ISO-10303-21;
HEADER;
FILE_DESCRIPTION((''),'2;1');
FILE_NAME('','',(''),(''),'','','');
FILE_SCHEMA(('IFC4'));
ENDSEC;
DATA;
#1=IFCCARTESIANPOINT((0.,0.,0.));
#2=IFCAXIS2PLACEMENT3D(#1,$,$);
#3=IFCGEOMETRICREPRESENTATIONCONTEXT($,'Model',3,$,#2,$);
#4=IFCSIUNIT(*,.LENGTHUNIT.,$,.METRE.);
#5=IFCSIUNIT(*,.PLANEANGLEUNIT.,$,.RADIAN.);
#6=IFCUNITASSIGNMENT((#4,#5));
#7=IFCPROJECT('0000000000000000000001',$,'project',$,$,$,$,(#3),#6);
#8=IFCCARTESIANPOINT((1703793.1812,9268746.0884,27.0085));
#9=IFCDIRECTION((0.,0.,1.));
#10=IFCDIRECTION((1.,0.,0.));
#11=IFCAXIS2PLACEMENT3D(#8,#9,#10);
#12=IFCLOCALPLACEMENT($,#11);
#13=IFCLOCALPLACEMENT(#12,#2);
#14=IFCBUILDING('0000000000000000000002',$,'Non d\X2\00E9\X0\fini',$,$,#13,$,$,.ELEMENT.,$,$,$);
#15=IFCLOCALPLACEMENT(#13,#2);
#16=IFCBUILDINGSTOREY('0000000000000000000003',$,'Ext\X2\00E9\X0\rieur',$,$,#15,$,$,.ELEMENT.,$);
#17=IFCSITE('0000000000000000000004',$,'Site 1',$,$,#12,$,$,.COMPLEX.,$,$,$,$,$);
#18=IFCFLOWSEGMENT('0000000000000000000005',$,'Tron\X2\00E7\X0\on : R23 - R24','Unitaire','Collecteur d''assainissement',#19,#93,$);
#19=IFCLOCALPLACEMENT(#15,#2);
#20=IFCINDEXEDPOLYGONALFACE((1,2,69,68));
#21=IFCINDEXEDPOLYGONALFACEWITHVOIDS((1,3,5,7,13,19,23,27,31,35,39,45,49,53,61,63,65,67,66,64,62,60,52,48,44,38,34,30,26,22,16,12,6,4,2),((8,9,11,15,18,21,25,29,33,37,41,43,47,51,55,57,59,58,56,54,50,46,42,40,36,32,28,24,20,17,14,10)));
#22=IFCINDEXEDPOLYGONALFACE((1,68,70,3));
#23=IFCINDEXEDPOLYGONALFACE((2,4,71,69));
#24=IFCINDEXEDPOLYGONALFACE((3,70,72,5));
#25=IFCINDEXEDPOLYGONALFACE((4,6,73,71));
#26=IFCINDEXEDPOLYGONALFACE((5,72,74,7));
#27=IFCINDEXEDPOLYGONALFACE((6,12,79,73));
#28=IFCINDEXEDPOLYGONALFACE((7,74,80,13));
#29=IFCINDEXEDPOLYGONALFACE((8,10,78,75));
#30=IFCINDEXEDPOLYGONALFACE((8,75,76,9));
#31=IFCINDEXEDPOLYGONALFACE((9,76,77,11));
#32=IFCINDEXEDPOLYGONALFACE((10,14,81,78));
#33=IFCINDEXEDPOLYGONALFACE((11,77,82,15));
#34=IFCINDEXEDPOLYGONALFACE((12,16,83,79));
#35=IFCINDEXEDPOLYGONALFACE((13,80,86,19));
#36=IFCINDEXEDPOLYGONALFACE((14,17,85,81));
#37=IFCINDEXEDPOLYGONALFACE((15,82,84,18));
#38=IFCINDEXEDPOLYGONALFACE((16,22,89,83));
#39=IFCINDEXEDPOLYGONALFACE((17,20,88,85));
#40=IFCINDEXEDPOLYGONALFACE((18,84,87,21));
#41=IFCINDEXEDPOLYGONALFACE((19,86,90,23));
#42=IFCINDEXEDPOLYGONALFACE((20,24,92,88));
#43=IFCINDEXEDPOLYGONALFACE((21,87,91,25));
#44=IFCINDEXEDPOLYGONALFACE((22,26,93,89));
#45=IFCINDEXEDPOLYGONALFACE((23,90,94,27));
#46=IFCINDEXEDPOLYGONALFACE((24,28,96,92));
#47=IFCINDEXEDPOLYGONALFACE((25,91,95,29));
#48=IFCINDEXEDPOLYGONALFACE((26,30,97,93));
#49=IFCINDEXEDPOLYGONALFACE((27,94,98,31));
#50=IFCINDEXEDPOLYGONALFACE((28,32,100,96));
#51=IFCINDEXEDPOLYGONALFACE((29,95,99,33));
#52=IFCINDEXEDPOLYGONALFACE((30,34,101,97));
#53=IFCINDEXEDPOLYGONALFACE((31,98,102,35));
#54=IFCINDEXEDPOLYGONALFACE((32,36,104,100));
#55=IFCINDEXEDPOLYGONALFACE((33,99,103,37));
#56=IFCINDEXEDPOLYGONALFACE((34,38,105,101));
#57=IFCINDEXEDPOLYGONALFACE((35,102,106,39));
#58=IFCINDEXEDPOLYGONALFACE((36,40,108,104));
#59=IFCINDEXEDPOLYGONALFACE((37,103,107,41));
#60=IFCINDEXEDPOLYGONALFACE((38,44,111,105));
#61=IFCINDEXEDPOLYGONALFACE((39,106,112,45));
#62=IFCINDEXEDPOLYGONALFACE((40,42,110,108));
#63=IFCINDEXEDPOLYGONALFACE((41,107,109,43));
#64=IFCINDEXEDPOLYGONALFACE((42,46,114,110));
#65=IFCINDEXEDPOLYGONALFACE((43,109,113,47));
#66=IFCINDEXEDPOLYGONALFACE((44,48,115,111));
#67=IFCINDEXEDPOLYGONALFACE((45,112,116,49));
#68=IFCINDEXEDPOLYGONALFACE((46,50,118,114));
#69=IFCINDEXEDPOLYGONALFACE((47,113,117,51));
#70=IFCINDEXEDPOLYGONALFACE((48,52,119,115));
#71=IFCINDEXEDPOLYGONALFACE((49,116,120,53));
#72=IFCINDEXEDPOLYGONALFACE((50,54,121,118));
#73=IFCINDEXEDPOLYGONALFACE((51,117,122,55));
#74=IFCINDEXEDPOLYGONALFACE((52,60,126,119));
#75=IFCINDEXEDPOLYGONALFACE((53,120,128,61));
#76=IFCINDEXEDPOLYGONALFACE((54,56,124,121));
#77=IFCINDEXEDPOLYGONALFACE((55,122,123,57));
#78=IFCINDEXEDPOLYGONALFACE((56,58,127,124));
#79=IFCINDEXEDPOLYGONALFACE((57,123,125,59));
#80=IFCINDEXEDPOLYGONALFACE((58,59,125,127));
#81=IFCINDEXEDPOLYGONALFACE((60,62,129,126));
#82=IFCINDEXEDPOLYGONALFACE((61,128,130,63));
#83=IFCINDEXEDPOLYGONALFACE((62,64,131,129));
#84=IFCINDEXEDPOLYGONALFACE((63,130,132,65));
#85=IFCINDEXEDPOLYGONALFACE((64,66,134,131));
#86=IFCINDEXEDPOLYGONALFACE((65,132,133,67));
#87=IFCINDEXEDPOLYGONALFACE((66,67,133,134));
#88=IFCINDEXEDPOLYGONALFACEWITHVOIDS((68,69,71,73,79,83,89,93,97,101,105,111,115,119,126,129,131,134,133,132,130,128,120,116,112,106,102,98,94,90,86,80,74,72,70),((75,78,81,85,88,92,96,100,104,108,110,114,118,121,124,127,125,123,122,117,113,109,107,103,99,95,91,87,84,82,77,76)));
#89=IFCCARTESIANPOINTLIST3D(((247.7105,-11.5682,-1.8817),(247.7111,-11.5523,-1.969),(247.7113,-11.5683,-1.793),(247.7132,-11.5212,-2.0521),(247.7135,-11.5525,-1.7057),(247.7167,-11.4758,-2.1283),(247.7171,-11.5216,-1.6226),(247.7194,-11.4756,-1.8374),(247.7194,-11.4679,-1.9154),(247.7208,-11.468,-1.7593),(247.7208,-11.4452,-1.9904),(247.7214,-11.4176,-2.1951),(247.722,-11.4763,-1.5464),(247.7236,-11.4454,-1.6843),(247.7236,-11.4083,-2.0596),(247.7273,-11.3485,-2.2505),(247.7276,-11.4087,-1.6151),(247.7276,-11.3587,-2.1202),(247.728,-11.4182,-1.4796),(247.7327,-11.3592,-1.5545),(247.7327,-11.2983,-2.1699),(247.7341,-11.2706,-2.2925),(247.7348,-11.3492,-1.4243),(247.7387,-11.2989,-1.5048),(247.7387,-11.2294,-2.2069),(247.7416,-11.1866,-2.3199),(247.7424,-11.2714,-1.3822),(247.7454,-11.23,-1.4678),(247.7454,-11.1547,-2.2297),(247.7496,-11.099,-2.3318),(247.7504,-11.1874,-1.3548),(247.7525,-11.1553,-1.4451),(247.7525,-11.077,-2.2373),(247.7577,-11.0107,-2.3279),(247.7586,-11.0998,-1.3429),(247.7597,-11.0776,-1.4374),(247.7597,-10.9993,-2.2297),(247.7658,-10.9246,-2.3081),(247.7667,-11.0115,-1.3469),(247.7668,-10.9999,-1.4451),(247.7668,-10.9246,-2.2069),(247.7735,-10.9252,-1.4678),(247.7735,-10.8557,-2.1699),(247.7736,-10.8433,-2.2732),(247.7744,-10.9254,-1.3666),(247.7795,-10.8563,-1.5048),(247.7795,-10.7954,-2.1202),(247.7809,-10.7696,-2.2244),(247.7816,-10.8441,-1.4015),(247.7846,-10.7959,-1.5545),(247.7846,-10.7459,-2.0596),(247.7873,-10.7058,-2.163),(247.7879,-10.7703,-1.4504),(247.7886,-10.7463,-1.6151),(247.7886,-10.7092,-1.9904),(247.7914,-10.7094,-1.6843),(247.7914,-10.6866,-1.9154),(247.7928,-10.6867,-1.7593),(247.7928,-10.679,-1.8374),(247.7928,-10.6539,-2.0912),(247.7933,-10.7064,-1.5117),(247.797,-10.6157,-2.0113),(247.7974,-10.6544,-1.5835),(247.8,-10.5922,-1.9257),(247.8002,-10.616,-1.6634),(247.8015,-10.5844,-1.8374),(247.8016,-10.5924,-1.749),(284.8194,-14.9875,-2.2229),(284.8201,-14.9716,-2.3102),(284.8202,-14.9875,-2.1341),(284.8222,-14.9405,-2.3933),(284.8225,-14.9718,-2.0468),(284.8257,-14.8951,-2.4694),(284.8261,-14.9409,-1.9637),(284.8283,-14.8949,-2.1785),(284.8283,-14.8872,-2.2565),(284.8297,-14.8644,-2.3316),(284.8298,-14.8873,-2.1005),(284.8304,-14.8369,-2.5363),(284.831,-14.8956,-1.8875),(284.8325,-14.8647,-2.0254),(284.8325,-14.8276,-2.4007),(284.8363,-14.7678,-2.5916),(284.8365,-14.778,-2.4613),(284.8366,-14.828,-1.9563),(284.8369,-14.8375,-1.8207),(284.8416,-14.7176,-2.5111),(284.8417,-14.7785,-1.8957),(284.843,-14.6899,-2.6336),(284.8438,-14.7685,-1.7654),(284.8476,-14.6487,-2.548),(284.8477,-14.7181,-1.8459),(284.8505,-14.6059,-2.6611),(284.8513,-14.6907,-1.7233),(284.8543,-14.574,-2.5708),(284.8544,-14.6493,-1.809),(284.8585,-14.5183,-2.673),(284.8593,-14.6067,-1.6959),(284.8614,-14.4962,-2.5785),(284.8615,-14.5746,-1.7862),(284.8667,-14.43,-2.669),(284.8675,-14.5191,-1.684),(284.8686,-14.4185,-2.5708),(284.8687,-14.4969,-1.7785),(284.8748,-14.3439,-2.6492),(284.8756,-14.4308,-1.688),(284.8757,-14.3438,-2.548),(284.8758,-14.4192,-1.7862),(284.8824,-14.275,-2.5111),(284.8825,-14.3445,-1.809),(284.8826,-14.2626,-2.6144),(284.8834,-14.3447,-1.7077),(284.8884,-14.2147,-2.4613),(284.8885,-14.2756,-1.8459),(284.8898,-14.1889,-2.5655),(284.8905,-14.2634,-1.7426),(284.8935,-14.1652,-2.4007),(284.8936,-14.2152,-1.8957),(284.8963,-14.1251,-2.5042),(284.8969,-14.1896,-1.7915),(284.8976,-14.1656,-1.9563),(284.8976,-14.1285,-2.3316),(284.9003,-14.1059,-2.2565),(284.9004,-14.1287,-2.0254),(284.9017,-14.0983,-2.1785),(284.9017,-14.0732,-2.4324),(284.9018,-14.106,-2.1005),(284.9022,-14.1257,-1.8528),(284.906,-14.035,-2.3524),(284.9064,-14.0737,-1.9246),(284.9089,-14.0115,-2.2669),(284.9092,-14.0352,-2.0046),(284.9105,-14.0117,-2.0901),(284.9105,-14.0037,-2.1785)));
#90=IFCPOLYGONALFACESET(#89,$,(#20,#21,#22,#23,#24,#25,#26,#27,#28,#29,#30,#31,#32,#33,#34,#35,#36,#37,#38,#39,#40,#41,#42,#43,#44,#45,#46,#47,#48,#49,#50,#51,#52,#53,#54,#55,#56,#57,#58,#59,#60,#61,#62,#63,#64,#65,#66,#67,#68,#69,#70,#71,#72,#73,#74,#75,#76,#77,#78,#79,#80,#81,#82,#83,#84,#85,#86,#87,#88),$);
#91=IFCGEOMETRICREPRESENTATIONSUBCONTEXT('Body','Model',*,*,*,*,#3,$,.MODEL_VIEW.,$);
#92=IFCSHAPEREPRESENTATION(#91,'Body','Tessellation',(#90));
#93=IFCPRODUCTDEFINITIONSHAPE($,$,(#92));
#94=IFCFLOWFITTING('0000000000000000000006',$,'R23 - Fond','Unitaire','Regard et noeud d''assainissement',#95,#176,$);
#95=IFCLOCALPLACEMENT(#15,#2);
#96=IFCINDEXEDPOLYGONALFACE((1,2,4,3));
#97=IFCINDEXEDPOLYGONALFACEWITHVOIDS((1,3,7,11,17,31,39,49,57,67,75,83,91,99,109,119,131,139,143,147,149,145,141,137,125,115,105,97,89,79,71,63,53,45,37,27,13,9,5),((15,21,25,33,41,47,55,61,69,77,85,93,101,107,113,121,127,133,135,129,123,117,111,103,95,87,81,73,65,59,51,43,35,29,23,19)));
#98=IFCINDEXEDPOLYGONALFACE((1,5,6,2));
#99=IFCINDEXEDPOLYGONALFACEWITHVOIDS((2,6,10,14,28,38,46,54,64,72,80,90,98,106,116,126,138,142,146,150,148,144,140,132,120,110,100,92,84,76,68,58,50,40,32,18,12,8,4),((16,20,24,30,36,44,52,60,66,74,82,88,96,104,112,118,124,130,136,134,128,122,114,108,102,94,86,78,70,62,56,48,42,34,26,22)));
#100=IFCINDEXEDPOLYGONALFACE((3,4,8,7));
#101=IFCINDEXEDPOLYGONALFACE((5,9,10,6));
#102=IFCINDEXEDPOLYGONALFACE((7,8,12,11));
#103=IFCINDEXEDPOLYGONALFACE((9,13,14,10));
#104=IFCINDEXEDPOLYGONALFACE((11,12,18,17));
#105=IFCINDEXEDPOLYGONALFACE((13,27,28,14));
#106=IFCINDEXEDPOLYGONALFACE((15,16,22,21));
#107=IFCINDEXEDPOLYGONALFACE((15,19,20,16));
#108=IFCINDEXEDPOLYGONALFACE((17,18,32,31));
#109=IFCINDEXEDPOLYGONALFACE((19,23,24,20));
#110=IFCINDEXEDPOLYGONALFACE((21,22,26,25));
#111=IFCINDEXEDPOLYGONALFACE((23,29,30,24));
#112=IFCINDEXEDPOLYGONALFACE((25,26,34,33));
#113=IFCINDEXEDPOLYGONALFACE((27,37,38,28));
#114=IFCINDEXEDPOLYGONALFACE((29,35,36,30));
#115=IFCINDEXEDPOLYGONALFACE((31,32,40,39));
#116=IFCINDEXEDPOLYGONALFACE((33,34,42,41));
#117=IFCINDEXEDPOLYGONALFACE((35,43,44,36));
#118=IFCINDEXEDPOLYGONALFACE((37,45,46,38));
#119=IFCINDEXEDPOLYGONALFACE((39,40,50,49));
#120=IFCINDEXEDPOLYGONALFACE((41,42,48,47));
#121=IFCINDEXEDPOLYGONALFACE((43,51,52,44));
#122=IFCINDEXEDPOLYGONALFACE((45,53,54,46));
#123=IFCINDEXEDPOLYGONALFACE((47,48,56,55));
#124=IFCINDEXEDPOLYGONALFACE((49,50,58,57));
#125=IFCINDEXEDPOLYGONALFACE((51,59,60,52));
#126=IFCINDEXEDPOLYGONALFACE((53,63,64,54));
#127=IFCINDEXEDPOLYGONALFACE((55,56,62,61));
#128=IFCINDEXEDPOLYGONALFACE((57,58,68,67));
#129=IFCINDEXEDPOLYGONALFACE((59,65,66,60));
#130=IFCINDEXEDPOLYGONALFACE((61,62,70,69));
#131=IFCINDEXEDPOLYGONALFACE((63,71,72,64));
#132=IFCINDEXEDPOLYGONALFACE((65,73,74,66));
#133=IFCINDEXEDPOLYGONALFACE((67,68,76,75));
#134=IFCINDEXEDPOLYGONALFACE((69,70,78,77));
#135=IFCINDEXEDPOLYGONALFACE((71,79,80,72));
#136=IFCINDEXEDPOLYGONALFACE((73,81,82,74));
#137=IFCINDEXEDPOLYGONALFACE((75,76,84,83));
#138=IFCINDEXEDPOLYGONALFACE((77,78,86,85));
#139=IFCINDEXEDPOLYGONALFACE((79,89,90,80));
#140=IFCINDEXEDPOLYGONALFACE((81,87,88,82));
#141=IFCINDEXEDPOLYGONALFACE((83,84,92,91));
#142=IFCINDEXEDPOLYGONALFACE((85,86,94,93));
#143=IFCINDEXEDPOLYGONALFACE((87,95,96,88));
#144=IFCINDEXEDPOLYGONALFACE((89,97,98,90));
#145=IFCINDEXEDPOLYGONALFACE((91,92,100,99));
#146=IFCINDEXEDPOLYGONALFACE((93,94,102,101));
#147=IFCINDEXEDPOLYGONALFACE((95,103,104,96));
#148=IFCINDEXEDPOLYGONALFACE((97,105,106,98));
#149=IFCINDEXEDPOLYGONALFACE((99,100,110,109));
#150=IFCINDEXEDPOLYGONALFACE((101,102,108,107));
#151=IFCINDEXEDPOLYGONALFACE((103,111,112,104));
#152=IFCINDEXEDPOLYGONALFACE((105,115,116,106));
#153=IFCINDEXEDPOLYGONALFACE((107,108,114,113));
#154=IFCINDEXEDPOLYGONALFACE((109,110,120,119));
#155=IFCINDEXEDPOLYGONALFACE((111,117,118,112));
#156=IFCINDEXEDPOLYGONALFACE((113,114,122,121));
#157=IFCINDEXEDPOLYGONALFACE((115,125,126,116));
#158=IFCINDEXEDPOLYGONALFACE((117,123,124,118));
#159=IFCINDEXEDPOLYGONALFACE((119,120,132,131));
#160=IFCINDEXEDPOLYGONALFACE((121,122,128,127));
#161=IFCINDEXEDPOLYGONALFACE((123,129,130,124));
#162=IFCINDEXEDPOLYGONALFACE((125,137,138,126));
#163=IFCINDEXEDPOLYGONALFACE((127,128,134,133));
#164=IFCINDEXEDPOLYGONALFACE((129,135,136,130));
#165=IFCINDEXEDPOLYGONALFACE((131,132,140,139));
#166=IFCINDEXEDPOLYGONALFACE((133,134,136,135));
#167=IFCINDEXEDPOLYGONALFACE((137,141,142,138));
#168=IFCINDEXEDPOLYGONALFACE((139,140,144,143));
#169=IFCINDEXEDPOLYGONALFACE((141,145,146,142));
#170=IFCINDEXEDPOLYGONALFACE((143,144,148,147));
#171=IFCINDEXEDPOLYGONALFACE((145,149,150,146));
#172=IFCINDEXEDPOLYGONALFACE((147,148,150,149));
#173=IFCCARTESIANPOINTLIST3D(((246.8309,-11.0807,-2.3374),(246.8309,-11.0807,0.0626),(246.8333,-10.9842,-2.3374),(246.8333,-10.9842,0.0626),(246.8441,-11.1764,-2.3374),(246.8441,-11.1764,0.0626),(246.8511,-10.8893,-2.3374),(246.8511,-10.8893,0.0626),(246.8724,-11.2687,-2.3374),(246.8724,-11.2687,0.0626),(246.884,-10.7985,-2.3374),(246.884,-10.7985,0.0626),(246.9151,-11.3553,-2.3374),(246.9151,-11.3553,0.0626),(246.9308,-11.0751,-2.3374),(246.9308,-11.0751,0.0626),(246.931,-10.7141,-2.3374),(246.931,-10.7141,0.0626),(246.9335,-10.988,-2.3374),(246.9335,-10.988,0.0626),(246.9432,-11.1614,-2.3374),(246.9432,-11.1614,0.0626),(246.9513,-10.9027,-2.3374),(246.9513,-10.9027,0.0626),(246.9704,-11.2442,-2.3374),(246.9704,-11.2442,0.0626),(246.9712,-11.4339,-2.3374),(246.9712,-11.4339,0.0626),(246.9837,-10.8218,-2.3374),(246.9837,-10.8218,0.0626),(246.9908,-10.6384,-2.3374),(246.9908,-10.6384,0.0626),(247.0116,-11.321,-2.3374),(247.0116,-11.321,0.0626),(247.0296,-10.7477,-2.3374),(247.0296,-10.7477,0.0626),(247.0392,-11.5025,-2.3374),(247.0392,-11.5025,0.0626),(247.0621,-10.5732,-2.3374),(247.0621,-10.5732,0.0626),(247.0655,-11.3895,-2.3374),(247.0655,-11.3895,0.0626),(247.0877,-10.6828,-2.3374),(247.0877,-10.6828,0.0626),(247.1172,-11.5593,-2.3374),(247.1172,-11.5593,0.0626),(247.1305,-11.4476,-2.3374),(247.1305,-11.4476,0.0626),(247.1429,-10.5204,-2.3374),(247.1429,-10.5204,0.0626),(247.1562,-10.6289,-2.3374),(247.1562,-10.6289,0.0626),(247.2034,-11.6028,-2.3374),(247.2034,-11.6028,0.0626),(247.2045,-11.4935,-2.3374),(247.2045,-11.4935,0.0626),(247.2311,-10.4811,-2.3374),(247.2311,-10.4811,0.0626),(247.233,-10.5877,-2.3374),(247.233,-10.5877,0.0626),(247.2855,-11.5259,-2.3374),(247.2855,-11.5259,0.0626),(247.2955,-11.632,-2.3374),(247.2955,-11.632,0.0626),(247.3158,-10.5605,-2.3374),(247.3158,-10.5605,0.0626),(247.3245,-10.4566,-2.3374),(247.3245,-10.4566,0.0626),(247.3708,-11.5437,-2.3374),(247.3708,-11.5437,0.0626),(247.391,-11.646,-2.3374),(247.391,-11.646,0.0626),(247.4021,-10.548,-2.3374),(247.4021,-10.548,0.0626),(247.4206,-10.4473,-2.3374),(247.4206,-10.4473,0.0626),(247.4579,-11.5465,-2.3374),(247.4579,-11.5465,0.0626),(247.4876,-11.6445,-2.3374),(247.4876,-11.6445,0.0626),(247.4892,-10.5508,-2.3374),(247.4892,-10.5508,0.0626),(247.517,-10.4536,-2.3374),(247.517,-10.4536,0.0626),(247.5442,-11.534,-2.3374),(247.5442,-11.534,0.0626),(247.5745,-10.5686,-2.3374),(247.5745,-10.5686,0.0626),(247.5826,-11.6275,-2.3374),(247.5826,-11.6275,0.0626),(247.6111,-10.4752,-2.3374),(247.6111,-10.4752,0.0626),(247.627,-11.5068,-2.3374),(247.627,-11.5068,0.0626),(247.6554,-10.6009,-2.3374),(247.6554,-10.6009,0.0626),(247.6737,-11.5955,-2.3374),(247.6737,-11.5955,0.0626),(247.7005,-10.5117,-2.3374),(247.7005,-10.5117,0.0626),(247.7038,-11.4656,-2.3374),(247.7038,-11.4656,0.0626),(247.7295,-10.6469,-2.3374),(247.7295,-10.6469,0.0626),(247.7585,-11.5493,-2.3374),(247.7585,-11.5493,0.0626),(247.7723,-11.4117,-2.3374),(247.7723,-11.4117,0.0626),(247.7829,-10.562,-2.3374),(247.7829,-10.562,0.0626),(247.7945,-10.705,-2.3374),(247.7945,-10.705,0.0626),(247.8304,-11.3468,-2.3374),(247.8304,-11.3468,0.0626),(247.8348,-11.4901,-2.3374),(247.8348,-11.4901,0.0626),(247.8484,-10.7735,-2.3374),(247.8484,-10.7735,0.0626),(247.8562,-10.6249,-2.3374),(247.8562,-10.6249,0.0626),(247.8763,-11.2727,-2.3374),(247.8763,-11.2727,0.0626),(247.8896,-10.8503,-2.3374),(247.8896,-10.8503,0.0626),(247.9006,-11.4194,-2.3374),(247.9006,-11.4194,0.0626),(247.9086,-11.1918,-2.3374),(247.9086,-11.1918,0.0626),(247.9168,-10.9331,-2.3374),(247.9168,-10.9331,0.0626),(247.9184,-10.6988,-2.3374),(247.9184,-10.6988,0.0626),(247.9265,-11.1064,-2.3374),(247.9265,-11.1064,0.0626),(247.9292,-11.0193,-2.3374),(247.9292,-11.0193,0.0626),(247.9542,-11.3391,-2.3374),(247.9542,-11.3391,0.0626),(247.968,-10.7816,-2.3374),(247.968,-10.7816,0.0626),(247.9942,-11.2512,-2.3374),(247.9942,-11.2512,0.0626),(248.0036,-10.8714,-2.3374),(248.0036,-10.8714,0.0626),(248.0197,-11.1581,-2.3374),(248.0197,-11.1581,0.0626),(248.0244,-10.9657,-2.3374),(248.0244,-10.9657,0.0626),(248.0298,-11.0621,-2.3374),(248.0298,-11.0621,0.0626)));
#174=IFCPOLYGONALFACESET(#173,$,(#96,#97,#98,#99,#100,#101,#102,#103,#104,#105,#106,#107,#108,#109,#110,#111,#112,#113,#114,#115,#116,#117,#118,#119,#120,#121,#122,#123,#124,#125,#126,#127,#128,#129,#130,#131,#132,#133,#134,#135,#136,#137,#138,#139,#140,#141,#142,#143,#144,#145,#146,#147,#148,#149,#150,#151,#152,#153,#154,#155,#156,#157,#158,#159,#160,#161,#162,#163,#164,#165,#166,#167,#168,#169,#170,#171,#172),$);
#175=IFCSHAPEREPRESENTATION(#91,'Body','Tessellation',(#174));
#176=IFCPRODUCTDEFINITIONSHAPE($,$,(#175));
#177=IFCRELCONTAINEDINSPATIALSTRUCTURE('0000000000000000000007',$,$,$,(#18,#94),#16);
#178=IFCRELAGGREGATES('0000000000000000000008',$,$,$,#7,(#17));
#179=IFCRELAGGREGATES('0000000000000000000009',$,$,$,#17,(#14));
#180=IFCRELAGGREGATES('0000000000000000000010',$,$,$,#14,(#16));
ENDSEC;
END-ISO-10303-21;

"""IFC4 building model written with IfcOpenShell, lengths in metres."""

from ifc_helpers import new_model, si_unit, frame, origin, origin_2d, place, context, subcontext, project, spatial, hollow_circle, extrude, element, save


model = new_model("IFC4")

# Units and contexts
model_context = context("Model", 3, world=origin())
body_context = subcontext(model_context, "Body", "Model", "MODEL_VIEW")
ifc_project = project(units=[si_unit("LENGTHUNIT", "METRE"), si_unit("PLANEANGLEUNIT", "RADIAN")], contexts=[model_context])

# Site, building, storey
site_placement = place(None, frame((1703793.1812, 9268746.0884, 27.0085), z_axis=(0.0, 0.0, 1.0), x_axis=(1.0, 0.0, 0.0)))
site = spatial("IfcSite", under=ifc_project, at=site_placement, Name="Site 1", CompositionType="COMPLEX")
building_placement = place(site_placement, origin())
building = spatial("IfcBuilding", under=site, at=building_placement, Name="Non défini", CompositionType="ELEMENT")
storey_placement = place(building_placement, origin())
storey = spatial("IfcBuildingStorey", under=building, at=storey_placement, Name="Extérieur", CompositionType="ELEMENT")

# Flow segment
flow_segment_1_placement = place(storey_placement, origin())
element("IfcFlowSegment", 1, at=flow_segment_1_placement, inside=storey, Name="Tronçon : R23 - R24", Description="Unitaire", ObjectType="Collecteur d'assainissement", context=body_context, shape_type="SweptSolid", body=[
    extrude(hollow_circle(Radius=0.495, WallThickness=0.095, at=origin_2d()), frame((247.7561, -11.0773, -1.8374), z_axis=(0.99574, -0.091749, -0.009153), x_axis=(0.091753, 0.995782, 0.0)), (0.0, 0.0, 1.0), 37.2677),
])

# Flow fitting
flow_fitting_1_placement = place(storey_placement, origin())
element("IfcFlowFitting", 2, at=flow_fitting_1_placement, inside=storey, Name="R23 - Fond", Description="Unitaire", ObjectType="Regard et noeud d'assainissement", context=body_context, shape_type="SweptSolid", body=[
    extrude(hollow_circle(Radius=0.6, WallThickness=0.1, at=origin_2d()), frame((247.43, -11.0472, -2.3374), z_axis=(0.0, 0.0, 1.0), x_axis=(0.450883, 0.892583, 0.0)), (0.0, 0.0, 1.0), 2.4),
])

save(model, "model.ifc")
